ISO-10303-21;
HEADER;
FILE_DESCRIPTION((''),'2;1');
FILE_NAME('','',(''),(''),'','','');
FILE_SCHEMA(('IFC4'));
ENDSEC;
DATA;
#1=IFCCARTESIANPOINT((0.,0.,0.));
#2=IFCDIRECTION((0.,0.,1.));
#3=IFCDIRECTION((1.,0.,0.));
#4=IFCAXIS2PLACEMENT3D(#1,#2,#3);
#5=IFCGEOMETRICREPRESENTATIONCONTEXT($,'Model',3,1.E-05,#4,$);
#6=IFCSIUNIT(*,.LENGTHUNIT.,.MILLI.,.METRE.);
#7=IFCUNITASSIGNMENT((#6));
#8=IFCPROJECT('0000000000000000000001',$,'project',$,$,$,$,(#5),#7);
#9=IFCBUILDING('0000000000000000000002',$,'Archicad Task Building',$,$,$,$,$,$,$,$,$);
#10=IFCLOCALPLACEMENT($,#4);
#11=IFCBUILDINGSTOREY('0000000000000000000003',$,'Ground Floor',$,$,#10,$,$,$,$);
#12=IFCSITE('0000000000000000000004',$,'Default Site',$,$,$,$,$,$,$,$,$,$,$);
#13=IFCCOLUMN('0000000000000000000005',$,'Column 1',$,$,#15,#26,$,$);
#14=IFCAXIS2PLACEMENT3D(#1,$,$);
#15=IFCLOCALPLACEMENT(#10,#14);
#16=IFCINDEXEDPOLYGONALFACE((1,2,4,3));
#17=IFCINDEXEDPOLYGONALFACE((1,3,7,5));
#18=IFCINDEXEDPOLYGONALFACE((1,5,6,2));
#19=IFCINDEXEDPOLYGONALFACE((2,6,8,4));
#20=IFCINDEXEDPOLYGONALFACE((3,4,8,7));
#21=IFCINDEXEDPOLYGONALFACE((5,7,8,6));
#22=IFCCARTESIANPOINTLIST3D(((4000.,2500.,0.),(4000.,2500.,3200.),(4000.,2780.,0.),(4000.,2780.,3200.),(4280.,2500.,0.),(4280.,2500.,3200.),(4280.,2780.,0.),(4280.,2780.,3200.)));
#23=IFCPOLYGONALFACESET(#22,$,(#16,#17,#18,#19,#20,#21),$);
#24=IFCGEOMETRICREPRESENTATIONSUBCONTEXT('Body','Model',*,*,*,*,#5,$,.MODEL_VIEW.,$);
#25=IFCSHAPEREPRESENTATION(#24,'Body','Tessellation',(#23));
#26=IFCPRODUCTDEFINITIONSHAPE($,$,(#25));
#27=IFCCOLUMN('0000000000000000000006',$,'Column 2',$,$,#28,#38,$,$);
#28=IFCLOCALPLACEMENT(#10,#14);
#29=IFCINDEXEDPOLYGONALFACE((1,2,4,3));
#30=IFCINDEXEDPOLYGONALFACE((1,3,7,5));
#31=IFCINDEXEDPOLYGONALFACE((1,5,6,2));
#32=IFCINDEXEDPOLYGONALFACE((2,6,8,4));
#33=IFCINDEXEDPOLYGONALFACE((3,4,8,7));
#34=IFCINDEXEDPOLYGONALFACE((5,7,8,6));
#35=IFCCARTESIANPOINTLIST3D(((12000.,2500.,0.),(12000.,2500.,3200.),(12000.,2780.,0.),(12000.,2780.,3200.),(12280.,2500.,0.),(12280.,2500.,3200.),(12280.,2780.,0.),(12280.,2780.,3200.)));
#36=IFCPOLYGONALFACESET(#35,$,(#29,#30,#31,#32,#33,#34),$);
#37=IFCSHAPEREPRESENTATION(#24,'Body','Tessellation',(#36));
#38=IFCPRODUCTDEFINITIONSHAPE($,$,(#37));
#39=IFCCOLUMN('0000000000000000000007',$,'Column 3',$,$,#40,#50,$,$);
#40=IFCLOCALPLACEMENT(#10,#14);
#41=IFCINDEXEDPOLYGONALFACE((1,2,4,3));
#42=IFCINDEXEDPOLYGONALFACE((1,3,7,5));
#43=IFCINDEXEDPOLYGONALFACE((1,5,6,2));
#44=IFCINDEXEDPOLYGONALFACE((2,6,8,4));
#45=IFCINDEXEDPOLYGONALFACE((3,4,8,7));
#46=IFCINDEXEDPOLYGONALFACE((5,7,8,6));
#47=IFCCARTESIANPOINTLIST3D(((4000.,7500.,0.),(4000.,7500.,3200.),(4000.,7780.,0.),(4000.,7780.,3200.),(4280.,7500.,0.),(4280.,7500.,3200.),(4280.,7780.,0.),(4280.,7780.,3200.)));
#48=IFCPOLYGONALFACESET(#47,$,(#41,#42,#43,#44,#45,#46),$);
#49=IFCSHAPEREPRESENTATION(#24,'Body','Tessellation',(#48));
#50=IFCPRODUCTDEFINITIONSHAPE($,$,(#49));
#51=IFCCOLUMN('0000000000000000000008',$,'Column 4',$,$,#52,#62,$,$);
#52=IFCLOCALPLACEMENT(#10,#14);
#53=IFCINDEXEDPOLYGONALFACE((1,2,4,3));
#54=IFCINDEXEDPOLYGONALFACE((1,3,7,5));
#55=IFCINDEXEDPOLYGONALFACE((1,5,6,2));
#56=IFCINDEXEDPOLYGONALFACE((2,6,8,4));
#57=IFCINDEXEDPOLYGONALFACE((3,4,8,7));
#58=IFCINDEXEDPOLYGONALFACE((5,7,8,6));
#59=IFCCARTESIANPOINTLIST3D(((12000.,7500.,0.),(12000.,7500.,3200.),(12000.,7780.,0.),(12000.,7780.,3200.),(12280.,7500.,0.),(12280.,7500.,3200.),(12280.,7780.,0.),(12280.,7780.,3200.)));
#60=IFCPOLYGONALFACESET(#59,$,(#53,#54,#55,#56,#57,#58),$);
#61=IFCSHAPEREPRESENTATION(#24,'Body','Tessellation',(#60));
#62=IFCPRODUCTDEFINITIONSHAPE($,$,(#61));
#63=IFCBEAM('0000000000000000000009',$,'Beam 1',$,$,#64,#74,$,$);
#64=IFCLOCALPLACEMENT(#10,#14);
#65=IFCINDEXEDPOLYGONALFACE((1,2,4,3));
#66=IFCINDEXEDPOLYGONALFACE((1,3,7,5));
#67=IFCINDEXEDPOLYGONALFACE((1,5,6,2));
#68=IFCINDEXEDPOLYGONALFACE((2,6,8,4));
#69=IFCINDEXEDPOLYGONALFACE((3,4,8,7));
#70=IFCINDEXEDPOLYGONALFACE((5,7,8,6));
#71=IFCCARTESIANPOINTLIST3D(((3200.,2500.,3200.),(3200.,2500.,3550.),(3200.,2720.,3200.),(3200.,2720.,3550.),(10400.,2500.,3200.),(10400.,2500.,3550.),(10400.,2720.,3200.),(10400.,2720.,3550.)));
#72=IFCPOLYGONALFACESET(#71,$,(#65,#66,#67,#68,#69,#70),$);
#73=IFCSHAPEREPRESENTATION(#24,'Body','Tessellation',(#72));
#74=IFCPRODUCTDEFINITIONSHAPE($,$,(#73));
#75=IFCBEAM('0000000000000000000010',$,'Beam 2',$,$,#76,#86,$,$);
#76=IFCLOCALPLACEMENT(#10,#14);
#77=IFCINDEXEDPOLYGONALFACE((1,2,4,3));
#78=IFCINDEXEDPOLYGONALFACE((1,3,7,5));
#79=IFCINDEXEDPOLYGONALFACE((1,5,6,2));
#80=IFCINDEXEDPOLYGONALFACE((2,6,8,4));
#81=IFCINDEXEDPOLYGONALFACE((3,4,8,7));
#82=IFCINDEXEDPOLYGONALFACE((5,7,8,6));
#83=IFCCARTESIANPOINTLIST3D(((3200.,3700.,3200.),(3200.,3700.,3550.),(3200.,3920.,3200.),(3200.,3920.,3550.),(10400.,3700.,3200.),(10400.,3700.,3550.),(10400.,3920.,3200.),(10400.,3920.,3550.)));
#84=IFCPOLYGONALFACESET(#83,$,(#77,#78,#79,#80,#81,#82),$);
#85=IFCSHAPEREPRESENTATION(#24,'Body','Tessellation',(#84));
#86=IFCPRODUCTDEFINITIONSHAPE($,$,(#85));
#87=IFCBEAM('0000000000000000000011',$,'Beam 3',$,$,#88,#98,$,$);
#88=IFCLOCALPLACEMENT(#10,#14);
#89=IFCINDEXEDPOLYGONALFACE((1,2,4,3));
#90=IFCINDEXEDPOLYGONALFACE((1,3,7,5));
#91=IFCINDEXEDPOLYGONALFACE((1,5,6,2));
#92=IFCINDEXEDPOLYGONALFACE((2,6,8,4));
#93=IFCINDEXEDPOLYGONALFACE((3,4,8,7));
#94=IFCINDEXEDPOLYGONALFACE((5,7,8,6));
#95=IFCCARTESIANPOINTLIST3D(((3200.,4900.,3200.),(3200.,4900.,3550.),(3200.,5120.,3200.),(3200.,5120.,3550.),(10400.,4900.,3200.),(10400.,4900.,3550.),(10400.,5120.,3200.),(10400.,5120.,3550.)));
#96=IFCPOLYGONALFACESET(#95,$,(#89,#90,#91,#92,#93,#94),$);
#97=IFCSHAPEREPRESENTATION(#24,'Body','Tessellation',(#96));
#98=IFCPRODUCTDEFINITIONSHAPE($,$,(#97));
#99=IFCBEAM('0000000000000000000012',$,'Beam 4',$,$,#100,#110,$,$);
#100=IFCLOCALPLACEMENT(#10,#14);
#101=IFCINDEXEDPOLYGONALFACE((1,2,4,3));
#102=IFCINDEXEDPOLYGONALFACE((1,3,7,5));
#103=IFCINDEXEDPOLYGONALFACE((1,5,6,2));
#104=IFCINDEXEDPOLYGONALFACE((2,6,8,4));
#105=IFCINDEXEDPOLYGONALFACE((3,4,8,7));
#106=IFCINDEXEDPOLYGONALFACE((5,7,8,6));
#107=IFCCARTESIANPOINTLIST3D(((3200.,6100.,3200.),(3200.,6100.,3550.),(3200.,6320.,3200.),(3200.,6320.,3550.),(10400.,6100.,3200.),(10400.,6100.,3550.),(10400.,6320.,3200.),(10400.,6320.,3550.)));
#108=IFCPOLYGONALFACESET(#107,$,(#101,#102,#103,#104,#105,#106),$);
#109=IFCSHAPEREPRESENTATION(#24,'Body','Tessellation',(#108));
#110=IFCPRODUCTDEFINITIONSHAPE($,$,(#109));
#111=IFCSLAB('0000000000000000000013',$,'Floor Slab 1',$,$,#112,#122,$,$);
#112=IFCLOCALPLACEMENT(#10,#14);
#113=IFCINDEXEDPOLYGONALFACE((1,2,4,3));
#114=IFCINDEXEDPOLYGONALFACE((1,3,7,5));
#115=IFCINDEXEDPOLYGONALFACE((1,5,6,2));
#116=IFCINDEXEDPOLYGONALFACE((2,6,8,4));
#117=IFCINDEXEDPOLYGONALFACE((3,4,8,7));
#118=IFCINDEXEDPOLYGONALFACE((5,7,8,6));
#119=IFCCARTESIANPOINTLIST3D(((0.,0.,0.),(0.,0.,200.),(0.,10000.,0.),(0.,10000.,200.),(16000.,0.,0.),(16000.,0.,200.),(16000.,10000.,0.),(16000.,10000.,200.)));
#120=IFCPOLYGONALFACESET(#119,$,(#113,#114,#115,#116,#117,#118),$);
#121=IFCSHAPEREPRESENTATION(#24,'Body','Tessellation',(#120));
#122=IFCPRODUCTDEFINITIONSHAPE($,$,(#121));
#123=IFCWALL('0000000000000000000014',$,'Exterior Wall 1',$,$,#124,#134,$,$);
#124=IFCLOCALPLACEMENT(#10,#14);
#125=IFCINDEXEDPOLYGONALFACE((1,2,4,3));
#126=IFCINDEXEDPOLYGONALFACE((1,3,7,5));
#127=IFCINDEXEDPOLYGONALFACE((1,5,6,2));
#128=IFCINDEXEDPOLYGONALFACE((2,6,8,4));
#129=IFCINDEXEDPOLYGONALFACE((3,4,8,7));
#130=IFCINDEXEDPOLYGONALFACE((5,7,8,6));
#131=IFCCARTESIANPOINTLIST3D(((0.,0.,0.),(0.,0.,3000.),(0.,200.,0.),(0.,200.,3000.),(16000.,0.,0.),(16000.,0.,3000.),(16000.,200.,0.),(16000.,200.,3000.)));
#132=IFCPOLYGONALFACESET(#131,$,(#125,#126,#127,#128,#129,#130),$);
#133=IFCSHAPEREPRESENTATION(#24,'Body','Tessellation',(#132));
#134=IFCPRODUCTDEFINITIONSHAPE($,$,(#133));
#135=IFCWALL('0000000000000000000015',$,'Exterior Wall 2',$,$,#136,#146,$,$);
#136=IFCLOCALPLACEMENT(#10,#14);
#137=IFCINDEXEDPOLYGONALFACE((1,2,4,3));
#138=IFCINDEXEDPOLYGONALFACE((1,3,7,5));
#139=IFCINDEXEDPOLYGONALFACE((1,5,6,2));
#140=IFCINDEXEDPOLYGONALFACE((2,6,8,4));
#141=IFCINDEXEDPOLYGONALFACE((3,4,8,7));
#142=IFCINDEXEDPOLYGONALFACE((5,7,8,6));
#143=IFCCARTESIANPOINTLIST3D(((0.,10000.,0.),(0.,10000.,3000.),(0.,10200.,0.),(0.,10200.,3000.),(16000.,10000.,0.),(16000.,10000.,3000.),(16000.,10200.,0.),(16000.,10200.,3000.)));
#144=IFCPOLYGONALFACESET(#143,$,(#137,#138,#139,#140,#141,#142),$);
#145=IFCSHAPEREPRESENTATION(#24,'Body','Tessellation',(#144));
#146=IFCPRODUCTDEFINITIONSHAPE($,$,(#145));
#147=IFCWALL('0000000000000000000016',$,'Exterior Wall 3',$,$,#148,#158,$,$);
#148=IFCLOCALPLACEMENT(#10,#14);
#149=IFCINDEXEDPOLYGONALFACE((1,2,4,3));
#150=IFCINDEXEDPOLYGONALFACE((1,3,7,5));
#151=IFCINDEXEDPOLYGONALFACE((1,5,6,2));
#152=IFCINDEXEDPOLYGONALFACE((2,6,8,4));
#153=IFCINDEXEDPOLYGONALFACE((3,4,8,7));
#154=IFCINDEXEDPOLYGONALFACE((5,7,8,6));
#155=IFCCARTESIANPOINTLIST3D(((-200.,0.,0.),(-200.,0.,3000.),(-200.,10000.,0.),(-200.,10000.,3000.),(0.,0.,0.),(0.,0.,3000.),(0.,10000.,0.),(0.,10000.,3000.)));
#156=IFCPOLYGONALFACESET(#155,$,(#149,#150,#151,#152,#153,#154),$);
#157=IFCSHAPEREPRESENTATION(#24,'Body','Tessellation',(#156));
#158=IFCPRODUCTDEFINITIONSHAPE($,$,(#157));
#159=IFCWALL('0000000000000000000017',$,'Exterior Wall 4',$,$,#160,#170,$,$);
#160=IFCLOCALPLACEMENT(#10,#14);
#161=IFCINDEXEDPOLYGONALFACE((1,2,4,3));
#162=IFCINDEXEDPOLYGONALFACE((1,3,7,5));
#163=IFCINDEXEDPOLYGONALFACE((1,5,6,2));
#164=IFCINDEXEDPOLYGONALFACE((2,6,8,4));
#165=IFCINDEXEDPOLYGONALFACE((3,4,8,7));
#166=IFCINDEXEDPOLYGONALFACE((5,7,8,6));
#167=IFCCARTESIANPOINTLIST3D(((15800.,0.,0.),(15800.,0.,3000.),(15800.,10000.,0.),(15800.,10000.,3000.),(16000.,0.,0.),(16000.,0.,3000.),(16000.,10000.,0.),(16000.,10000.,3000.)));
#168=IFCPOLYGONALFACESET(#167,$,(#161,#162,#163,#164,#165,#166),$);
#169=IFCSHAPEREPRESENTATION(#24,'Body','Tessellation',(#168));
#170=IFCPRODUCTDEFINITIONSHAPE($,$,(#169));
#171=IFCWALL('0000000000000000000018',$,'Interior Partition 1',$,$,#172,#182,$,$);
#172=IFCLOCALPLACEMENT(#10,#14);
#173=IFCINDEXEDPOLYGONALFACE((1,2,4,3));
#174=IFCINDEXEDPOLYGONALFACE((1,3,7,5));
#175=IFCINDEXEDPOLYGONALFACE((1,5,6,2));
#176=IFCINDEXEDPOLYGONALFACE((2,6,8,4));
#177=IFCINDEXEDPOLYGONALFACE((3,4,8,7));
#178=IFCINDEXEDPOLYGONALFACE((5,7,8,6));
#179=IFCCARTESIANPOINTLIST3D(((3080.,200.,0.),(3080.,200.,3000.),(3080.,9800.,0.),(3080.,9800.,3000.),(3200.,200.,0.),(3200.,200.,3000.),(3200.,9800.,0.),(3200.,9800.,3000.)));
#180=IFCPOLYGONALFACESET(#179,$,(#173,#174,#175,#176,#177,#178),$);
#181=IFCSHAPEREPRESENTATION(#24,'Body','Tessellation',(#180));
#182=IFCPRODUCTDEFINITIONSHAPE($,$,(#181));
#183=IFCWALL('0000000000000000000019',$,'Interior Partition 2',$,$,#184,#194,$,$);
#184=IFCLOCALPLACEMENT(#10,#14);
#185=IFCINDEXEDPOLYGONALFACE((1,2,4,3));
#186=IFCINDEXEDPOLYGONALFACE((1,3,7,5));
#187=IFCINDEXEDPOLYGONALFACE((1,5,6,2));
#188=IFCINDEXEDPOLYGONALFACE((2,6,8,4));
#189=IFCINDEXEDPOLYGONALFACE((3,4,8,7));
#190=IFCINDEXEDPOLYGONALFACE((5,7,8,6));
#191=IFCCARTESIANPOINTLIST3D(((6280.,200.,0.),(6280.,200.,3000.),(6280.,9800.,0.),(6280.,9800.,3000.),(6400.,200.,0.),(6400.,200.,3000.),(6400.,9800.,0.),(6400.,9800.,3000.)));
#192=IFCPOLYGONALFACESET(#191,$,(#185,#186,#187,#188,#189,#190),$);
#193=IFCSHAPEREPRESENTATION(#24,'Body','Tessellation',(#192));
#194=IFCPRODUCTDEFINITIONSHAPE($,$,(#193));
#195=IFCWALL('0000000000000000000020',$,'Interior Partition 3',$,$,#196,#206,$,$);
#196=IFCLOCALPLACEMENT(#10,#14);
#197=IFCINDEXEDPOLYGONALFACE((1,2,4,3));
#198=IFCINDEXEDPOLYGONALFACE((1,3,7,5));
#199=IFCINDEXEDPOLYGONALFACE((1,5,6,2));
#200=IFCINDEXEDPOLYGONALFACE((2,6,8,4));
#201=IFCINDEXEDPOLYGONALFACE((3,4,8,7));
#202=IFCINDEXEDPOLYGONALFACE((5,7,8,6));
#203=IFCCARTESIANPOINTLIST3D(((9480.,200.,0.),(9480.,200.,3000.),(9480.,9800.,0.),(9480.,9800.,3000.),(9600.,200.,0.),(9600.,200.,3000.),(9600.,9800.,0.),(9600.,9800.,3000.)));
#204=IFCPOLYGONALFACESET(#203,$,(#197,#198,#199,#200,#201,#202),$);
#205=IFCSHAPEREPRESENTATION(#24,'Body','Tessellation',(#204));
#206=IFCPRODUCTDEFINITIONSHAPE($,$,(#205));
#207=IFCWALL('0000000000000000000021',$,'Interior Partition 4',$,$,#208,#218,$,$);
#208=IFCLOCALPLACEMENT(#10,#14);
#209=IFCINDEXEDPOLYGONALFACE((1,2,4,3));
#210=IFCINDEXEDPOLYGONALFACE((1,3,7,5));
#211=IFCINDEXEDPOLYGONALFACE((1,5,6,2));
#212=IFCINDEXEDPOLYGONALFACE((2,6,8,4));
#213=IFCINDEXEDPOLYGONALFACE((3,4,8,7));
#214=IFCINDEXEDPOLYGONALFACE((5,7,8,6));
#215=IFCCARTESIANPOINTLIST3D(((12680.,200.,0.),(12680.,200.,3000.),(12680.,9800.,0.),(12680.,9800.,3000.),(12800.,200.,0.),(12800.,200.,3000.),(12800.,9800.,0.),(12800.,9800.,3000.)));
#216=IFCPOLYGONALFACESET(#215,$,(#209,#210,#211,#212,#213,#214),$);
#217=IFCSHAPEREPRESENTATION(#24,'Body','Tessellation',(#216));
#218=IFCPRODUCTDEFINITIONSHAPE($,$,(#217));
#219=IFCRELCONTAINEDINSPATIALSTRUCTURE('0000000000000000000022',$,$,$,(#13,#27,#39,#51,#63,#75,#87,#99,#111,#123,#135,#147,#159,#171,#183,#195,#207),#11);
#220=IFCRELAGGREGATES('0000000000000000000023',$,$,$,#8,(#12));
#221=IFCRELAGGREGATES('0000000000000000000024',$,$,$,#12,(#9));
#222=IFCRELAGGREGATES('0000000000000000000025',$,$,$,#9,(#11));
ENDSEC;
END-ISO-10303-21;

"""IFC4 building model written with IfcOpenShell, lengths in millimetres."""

from ifc_helpers import new_model, si_unit, frame, origin_with_axes, place, context, subcontext, project, spatial, indexed_curve, outline, extrude, element, save


model = new_model("IFC4")

# Units and contexts
model_context = context("Model", 3, precision=1e-05, world=origin_with_axes())
body_context = subcontext(model_context, "Body", "Model", "MODEL_VIEW")
ifc_project = project(units=[si_unit("LENGTHUNIT", "METRE", prefix="MILLI")], contexts=[model_context])

# Site, building, storey
site = spatial("IfcSite", under=ifc_project, Name="Default Site")
building = spatial("IfcBuilding", under=site, Name="Archicad Task Building")
storey_placement = place(None, origin_with_axes())
storey = spatial("IfcBuildingStorey", under=building, at=storey_placement, Name="Ground Floor")

# Columns
for number, where, z_axis, x_axis, name in (
    (1, (4000.0, 2500.0, 0.0), (0.0, 0.0, 1.0), (1.0, 0.0, 0.0), "Column 1"),
    (2, (12000.0, 2500.0, 0.0), (0.0, 0.0, 1.0), (1.0, 0.0, 0.0), "Column 2"),
    (3, (4000.0, 7500.0, 0.0), (0.0, 0.0, 1.0), (1.0, 0.0, 0.0), "Column 3"),
    (4, (12000.0, 7500.0, 0.0), (0.0, 0.0, 1.0), (1.0, 0.0, 0.0), "Column 4"),
):
    element("IfcColumn", number, at=place(storey_placement, frame(where, z_axis=z_axis, x_axis=x_axis)), inside=storey, Name=name, context=body_context, shape_type="SweptSolid", body=[
        extrude(outline(indexed_curve([(0.0, 0.0), (0.0, 280.0), (280.0, 280.0), (280.0, 0.0), (0.0, 0.0)], self_intersect=False)), origin_with_axes(), (0.0, 0.0, 1.0), 3200.0),
    ])

# Beams
for number, where, z_axis, x_axis, name in (
    (5, (3200.0, 2500.0, 3200.0), (0.0, 0.0, 1.0), (1.0, 0.0, 0.0), "Beam 1"),
    (6, (3200.0, 3700.0, 3200.0), (0.0, 0.0, 1.0), (1.0, 0.0, 0.0), "Beam 2"),
    (7, (3200.0, 4900.0, 3200.0), (0.0, 0.0, 1.0), (1.0, 0.0, 0.0), "Beam 3"),
    (8, (3200.0, 6100.0, 3200.0), (0.0, 0.0, 1.0), (1.0, 0.0, 0.0), "Beam 4"),
):
    element("IfcBeam", number, at=place(storey_placement, frame(where, z_axis=z_axis, x_axis=x_axis)), inside=storey, Name=name, context=body_context, shape_type="SweptSolid", body=[
        extrude(outline(indexed_curve([(0.0, 0.0), (0.0, 220.0), (7200.0, 220.0), (7200.0, 0.0), (0.0, 0.0)], self_intersect=False)), origin_with_axes(), (0.0, 0.0, 1.0), 350.0),
    ])

# Slab
slab_placement = place(storey_placement, origin_with_axes())
element("IfcSlab", 9, at=slab_placement, inside=storey, Name="Floor Slab 1", context=body_context, shape_type="SweptSolid", body=[
    extrude(outline(indexed_curve([(0.0, 0.0), (16000.0, 0.0), (16000.0, 10000.0), (0.0, 10000.0), (0.0, 0.0)])), None, (0.0, 0.0, 1.0), 200.0),
])

# Walls
for number, where, z_axis, x_axis, name in (
    (10, (0.0, 0.0, 0.0), (0.0, 0.0, 1.0), (1.0, 0.0, 0.0), "Exterior Wall 1"),
    (11, (0.0, 10000.0, 0.0), (0.0, 0.0, 1.0), (1.0, 0.0, 0.0), "Exterior Wall 2"),
):
    element("IfcWall", number, at=place(storey_placement, frame(where, z_axis=z_axis, x_axis=x_axis)), inside=storey, Name=name, context=body_context, shape_type="SweptSolid", body=[
        extrude(outline(indexed_curve([(0.0, 0.0), (0.0, 200.0), (16000.0, 200.0), (16000.0, 0.0), (0.0, 0.0)], self_intersect=False)), origin_with_axes(), (0.0, 0.0, 1.0), 3000.0),
    ])
for number, where, z_axis, x_axis, name in (
    (12, (0.0, 0.0, 0.0), (0.0, 0.0, 1.0), (0.0, 1.0, 0.0), "Exterior Wall 3"),
    (13, (16000.0, 0.0, 0.0), (0.0, 0.0, 1.0), (0.0, 1.0, 0.0), "Exterior Wall 4"),
):
    element("IfcWall", number, at=place(storey_placement, frame(where, z_axis=z_axis, x_axis=x_axis)), inside=storey, Name=name, context=body_context, shape_type="SweptSolid", body=[
        extrude(outline(indexed_curve([(0.0, 0.0), (0.0, 200.0), (10000.0, 200.0), (10000.0, 0.0), (0.0, 0.0)], self_intersect=False)), origin_with_axes(), (0.0, 0.0, 1.0), 3000.0),
    ])
for number, where, z_axis, x_axis, name in (
    (14, (3200.0, 200.0, 0.0), (0.0, 0.0, 1.0), (0.0, 1.0, 0.0), "Interior Partition 1"),
    (15, (6400.0, 200.0, 0.0), (0.0, 0.0, 1.0), (0.0, 1.0, 0.0), "Interior Partition 2"),
    (16, (9600.0, 200.0, 0.0), (0.0, 0.0, 1.0), (0.0, 1.0, 0.0), "Interior Partition 3"),
    (17, (12800.0, 200.0, 0.0), (0.0, 0.0, 1.0), (0.0, 1.0, 0.0), "Interior Partition 4"),
):
    element("IfcWall", number, at=place(storey_placement, frame(where, z_axis=z_axis, x_axis=x_axis)), inside=storey, Name=name, context=body_context, shape_type="SweptSolid", body=[
        extrude(outline(indexed_curve([(0.0, 0.0), (0.0, 120.0), (9600.0, 120.0), (9600.0, 0.0), (0.0, 0.0)], self_intersect=False)), origin_with_axes(), (0.0, 0.0, 1.0), 3000.0),
    ])

save(model, "model.ifc")
